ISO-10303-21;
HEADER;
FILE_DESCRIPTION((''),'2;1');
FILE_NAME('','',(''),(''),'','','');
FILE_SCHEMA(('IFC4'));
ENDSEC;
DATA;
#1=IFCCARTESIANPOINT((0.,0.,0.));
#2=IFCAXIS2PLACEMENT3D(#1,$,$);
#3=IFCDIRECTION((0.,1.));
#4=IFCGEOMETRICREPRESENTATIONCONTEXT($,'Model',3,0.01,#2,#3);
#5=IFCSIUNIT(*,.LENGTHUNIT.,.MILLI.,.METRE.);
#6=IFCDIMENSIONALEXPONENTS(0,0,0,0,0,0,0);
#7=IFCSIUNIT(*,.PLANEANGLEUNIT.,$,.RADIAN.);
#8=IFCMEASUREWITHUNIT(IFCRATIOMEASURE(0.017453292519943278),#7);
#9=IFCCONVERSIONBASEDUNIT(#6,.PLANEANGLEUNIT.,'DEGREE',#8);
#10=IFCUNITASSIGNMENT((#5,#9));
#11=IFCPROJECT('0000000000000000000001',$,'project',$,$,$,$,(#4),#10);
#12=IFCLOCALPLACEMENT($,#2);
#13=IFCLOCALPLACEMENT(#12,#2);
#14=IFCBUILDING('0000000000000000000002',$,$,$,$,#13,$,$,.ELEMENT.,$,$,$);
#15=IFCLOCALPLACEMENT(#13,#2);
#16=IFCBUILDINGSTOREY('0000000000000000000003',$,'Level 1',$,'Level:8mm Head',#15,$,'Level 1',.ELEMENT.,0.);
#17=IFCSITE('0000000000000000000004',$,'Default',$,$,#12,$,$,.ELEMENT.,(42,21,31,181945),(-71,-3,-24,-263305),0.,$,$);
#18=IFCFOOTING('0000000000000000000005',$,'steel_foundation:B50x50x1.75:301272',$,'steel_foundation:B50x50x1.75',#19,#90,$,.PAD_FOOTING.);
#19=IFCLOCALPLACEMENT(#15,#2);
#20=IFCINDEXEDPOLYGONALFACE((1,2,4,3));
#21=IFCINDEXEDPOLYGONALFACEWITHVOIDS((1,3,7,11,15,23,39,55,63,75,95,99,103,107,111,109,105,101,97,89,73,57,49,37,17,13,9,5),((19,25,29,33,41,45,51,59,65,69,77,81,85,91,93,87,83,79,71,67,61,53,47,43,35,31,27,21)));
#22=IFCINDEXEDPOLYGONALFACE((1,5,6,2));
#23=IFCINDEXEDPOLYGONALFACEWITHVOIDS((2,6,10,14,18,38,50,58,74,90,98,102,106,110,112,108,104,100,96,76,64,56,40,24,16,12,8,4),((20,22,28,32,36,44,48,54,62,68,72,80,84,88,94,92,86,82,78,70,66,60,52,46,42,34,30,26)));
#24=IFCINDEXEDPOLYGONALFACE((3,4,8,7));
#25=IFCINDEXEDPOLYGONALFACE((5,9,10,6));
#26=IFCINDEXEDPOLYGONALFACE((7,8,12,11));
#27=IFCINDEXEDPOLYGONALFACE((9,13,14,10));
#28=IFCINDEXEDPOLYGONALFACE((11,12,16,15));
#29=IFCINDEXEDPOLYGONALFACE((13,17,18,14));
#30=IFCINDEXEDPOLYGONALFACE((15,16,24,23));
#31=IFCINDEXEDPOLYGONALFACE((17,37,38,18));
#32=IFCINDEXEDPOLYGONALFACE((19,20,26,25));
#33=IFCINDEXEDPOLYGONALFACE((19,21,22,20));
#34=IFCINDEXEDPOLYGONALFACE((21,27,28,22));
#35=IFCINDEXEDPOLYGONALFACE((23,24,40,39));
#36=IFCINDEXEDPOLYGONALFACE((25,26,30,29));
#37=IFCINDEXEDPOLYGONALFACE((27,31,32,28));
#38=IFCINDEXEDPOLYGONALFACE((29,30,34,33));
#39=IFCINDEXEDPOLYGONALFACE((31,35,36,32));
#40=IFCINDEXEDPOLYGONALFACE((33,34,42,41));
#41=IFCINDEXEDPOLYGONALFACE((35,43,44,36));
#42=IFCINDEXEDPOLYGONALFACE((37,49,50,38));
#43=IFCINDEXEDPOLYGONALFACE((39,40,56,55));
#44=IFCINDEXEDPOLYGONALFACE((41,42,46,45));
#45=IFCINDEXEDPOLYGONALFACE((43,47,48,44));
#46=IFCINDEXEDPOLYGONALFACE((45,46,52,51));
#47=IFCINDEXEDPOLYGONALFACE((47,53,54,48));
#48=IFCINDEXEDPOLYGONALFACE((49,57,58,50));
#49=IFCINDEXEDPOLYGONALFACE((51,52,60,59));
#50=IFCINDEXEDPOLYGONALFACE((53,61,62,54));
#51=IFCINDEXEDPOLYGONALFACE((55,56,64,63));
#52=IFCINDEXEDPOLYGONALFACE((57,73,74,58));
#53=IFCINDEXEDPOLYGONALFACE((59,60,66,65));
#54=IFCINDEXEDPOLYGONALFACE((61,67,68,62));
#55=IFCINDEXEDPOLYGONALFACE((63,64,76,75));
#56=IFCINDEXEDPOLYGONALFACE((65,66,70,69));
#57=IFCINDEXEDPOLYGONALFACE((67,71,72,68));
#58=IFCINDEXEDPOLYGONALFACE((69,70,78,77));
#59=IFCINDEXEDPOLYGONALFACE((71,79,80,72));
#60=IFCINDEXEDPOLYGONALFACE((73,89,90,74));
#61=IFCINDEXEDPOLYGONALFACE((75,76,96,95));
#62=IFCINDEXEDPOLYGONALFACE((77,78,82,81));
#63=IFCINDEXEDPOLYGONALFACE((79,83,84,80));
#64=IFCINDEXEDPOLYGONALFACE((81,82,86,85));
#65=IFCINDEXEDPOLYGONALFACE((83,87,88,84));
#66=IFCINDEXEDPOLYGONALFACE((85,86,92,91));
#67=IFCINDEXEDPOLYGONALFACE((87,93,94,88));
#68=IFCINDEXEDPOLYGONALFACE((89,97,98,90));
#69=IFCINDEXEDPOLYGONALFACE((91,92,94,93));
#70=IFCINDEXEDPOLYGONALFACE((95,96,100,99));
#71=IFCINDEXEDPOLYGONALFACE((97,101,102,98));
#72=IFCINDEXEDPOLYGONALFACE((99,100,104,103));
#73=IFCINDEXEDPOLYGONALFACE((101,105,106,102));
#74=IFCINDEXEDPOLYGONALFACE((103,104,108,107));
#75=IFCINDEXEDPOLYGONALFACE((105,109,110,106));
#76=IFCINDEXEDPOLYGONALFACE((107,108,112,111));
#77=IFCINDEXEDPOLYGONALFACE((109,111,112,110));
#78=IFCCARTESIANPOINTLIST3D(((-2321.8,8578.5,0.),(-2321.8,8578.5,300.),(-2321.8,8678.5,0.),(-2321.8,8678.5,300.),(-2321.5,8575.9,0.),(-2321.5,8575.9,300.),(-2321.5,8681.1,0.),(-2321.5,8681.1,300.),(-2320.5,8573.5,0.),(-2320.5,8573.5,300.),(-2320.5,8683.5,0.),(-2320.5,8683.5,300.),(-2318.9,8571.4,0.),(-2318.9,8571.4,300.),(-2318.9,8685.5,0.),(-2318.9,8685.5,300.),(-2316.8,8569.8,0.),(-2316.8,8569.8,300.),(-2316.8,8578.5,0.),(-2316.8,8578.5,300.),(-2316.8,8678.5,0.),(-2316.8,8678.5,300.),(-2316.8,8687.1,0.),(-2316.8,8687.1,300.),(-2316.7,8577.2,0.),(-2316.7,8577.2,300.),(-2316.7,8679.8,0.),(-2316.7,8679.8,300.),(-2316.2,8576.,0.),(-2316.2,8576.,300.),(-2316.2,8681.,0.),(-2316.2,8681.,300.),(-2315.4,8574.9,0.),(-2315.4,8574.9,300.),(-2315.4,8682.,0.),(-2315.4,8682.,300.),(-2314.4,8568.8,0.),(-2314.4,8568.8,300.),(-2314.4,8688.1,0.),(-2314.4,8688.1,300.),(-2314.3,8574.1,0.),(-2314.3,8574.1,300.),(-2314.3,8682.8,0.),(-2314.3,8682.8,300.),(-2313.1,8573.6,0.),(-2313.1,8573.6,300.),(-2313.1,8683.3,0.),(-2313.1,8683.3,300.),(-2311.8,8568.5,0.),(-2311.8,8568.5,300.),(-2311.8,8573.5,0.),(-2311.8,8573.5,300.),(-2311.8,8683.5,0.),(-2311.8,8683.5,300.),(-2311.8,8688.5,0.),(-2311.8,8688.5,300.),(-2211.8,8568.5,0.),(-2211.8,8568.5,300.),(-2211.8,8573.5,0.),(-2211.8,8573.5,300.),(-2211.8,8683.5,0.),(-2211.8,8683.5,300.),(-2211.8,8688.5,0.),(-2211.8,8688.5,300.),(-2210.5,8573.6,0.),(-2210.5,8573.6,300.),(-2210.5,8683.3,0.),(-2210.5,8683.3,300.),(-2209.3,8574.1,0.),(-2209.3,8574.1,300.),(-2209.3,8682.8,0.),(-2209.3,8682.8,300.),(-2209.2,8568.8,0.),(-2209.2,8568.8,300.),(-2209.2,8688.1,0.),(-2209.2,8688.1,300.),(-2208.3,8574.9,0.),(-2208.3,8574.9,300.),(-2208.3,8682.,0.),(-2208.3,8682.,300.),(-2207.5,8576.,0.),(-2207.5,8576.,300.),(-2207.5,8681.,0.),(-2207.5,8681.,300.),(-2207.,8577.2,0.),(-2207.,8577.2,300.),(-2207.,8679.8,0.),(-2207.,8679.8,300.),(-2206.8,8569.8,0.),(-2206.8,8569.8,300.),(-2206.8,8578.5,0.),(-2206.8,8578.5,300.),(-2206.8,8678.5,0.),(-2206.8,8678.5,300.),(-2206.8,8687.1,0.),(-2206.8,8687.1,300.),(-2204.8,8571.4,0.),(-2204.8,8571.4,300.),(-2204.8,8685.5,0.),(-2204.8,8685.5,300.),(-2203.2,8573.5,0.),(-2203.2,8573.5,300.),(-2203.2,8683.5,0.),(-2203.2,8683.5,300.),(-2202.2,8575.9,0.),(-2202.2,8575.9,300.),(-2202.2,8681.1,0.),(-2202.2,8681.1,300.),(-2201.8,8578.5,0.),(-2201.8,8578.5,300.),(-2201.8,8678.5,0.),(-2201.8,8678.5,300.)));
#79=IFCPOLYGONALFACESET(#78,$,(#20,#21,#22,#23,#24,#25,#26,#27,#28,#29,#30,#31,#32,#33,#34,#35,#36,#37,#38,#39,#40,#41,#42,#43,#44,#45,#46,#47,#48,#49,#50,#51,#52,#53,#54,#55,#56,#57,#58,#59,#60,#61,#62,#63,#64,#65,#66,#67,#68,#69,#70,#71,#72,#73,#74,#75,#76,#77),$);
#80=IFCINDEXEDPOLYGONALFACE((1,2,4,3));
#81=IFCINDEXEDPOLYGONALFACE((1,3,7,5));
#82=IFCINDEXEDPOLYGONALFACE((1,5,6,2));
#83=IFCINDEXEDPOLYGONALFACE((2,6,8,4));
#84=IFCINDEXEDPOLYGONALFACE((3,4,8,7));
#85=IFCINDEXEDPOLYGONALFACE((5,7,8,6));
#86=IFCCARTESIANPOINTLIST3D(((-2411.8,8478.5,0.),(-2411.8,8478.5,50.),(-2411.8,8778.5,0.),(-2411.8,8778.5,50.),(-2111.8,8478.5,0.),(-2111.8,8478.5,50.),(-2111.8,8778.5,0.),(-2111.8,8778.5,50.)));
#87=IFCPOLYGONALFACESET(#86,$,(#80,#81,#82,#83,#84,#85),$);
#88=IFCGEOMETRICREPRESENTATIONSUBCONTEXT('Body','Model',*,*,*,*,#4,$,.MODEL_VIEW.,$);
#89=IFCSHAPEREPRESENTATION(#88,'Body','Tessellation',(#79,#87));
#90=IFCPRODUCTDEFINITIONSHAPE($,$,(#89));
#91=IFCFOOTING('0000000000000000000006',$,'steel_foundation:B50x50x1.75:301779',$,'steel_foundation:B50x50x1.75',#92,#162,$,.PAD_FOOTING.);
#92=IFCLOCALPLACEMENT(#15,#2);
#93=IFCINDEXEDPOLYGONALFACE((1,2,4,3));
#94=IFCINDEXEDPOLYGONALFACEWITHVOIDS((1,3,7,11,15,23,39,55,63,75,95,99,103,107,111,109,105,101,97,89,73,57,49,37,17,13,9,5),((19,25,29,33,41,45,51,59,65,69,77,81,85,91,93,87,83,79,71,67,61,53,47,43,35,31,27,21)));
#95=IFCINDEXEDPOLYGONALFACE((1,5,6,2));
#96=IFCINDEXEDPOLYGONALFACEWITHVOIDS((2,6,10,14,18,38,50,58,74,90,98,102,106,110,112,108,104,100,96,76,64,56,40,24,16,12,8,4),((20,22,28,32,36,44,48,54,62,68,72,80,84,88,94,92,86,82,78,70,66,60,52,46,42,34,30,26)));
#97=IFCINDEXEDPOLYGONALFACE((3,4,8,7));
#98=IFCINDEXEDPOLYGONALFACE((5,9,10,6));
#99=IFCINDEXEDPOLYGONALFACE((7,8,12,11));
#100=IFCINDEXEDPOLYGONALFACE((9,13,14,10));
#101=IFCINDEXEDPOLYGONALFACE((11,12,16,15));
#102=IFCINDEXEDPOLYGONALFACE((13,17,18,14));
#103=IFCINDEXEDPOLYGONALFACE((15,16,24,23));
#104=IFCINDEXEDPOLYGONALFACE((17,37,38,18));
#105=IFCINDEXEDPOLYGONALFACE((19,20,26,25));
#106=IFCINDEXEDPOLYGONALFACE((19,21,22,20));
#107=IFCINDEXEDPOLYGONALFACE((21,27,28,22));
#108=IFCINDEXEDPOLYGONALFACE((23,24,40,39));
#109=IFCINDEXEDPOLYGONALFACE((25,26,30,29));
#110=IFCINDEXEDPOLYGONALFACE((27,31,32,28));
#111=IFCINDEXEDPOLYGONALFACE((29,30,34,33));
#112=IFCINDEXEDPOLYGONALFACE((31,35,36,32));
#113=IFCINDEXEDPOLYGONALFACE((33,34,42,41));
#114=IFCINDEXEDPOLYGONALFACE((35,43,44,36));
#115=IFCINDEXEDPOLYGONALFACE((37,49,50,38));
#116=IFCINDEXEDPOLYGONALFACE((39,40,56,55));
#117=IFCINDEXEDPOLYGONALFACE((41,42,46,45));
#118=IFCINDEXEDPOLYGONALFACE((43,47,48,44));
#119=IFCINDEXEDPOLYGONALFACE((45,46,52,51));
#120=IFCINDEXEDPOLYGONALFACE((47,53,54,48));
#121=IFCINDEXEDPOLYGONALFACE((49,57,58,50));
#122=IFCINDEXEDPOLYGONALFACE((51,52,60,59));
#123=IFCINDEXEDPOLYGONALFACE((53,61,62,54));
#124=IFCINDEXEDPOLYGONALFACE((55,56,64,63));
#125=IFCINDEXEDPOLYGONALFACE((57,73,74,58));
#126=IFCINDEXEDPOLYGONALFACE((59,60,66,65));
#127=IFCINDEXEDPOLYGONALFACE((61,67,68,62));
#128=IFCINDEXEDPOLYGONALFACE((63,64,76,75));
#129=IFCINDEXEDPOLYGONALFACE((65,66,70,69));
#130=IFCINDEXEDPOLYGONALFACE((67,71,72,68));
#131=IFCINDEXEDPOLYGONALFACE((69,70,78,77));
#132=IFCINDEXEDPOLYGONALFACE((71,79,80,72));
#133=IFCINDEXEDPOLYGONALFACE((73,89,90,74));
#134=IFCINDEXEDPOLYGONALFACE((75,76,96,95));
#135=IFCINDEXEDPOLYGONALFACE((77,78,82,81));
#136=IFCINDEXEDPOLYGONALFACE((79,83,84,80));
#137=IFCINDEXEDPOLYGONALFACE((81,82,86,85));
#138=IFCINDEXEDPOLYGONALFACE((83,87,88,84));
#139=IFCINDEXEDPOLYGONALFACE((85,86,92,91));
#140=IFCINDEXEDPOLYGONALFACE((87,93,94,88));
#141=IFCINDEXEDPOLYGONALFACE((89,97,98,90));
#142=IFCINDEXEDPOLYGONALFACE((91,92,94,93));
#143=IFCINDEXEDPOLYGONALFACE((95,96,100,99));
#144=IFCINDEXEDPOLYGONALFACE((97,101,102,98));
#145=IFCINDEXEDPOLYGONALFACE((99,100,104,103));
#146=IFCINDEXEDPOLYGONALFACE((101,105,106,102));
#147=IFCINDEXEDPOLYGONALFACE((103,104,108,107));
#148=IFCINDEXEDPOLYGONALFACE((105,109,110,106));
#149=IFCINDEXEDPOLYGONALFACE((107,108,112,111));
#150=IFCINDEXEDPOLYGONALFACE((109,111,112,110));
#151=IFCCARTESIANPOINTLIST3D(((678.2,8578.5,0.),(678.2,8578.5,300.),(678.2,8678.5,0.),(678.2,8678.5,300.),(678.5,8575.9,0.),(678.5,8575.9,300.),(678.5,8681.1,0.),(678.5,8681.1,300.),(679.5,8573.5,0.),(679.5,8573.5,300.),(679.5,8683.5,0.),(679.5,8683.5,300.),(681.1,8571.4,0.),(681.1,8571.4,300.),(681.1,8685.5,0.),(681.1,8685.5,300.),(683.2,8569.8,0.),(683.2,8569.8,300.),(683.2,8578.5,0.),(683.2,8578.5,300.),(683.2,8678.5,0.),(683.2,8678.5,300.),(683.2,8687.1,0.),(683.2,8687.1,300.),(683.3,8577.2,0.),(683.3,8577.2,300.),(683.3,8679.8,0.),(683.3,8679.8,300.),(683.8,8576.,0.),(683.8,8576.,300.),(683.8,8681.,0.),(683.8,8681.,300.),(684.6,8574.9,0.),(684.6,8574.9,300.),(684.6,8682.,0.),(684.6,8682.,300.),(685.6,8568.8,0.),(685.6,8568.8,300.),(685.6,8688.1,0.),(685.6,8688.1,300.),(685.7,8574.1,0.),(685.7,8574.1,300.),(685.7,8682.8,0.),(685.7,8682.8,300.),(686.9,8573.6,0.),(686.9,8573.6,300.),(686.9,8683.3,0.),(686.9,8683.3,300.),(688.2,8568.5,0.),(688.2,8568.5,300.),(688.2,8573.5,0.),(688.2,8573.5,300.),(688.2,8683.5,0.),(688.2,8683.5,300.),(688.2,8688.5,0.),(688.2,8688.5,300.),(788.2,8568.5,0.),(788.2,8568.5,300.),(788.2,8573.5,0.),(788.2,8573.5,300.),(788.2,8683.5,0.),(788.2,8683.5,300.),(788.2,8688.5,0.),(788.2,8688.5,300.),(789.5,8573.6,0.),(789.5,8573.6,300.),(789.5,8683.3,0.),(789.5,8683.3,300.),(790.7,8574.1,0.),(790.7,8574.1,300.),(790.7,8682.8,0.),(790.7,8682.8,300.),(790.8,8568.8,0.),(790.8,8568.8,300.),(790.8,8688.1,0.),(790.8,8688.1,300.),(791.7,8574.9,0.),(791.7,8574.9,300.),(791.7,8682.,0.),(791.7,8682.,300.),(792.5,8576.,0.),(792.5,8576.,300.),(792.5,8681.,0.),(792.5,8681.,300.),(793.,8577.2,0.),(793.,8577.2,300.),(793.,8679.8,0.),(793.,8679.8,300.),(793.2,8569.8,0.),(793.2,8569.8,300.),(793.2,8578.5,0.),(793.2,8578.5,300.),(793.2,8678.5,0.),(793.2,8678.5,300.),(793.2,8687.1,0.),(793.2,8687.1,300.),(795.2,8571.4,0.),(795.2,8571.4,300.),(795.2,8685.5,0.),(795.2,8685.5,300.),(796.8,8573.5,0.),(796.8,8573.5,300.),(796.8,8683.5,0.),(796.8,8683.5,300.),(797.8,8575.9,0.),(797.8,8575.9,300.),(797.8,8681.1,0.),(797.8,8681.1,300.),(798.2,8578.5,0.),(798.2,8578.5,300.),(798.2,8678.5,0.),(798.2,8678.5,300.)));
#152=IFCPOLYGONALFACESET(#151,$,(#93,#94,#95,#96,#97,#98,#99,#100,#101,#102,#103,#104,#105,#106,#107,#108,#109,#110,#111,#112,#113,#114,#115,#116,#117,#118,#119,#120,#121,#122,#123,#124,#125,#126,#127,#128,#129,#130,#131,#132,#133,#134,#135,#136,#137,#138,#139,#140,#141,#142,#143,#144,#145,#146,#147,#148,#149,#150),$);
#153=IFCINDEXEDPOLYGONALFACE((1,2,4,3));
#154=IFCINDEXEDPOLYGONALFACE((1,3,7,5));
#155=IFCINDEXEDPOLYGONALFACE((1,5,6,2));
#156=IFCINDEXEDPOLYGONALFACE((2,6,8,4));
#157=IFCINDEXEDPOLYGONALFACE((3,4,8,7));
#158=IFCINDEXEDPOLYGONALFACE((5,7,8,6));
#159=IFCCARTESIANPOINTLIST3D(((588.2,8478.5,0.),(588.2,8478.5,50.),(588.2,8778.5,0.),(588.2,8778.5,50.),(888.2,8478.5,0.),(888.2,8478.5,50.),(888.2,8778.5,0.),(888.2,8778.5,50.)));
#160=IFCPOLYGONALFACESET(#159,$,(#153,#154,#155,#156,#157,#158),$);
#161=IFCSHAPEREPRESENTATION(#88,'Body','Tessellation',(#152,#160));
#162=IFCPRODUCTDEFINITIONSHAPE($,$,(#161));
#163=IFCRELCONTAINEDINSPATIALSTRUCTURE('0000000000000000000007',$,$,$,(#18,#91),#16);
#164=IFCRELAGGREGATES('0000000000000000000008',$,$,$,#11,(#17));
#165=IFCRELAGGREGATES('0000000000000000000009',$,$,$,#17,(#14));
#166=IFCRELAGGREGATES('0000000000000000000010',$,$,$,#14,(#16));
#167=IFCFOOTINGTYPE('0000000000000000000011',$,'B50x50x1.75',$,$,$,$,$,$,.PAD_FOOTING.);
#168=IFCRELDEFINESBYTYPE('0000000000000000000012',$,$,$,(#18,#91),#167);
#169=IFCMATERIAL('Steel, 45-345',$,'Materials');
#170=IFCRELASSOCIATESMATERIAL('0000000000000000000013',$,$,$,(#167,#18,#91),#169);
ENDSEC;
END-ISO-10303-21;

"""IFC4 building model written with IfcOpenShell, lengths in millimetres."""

from ifc_helpers import new_model, entity, si_unit, converted_unit, direction, frame, origin, place, context, subcontext, project, spatial, line, arc, indexed_curve, outline, extrude, source, transform, mapped, material, type_object, type_shapes, element, save


model = new_model("IFC4")

# Units and contexts
model_context = context("Model", 3, precision=0.01, world=origin(), true_north=direction((0.0, 1.0)))
body_context = subcontext(model_context, "Body", "Model", "MODEL_VIEW")
ifc_project = project(units=[si_unit("LENGTHUNIT", "METRE", prefix="MILLI"), converted_unit("PLANEANGLEUNIT", "DEGREE", entity("IfcRatioMeasure", 0.017453292519943278), si_unit("PLANEANGLEUNIT", "RADIAN"), dimensions=[0, 0, 0, 0, 0, 0, 0])], contexts=[model_context])

# Site, building, storey
site_placement = place(None, origin())
site = spatial("IfcSite", under=ifc_project, at=site_placement, Name="Default", CompositionType="ELEMENT", RefLatitude=(42, 21, 31, 181945), RefLongitude=(-71, -3, -24, -263305), RefElevation=0.0)
building_placement = place(site_placement, origin())
building = spatial("IfcBuilding", under=site, at=building_placement, CompositionType="ELEMENT")
storey_placement = place(building_placement, origin())
storey = spatial("IfcBuildingStorey", under=building, at=storey_placement, Name="Level 1", ObjectType="Level:8mm Head", LongName="Level 1", CompositionType="ELEMENT", Elevation=0.0)

# Footings
ifc_material_1 = material(Name="Steel, 45-345", Category="Materials")
footing_type = type_object("IfcFootingType", Name="B50x50x1.75", PredefinedType="PAD_FOOTING", material=ifc_material_1)
shared_shape_1 = source(origin(), body_context, "Body", "SweptSolid", [
    extrude(outline(indexed_curve([(-50.0, -60.0), (50.0, -60.0), (57.1, -57.1), (60.0, -50.0), (60.0, 50.0), (57.1, 57.1), (50.0, 60.0), (-50.0, 60.0), (-57.1, 57.1), (-60.0, 50.0), (-60.0, -50.0), (-57.1, -57.1)], segments=[line(1, 2), arc(2, 3, 4), line(4, 5), arc(5, 6, 7), line(7, 8), arc(8, 9, 10), line(10, 11), arc(11, 12, 1)], self_intersect=False), holes=[indexed_curve([(-50.0, -55.0), (-53.5, -53.5), (-55.0, -50.0), (-55.0, 50.0), (-53.5, 53.5), (-50.0, 55.0), (50.0, 55.0), (53.5, 53.5), (55.0, 50.0), (55.0, -50.0), (53.5, -53.5), (50.0, -55.0)], segments=[arc(1, 2, 3), line(3, 4), arc(4, 5, 6), line(6, 7), arc(7, 8, 9), line(9, 10), arc(10, 11, 12), line(12, 1)], self_intersect=False)]), frame((0.0, 0.0, 0.0), z_axis=(0.0, 0.0, 1.0), x_axis=(-1.0, 0.0, 0.0)), (0.0, 0.0, 1.0), 300.0),
    extrude(outline(indexed_curve([(-150.0, -150.0), (150.0, -150.0), (150.0, 150.0), (-150.0, 150.0), (-150.0, -150.0)], self_intersect=False)), frame((0.0, 0.0, 0.0), z_axis=(0.0, 0.0, 1.0), x_axis=(-1.0, 0.0, 0.0)), (0.0, 0.0, 1.0), 50.0),
])
type_shapes(footing_type, [shared_shape_1])
for number, where, name in (
    (1, (-2261.8, 8628.5, 0.0), "steel_foundation:B50x50x1.75:301272"),
    (2, (738.2, 8628.5, 0.0), "steel_foundation:B50x50x1.75:301779"),
):
    element("IfcFooting", number, at=place(storey_placement, frame(where)), inside=storey, type_object=footing_type, material=ifc_material_1, Name=name, ObjectType="steel_foundation:B50x50x1.75", PredefinedType="PAD_FOOTING", context=body_context, shape_type="MappedRepresentation", body=[
        mapped(shared_shape_1, transform((0.0, 0.0, 0.0), scale=1.0)),
    ])

save(model, "model.ifc")
